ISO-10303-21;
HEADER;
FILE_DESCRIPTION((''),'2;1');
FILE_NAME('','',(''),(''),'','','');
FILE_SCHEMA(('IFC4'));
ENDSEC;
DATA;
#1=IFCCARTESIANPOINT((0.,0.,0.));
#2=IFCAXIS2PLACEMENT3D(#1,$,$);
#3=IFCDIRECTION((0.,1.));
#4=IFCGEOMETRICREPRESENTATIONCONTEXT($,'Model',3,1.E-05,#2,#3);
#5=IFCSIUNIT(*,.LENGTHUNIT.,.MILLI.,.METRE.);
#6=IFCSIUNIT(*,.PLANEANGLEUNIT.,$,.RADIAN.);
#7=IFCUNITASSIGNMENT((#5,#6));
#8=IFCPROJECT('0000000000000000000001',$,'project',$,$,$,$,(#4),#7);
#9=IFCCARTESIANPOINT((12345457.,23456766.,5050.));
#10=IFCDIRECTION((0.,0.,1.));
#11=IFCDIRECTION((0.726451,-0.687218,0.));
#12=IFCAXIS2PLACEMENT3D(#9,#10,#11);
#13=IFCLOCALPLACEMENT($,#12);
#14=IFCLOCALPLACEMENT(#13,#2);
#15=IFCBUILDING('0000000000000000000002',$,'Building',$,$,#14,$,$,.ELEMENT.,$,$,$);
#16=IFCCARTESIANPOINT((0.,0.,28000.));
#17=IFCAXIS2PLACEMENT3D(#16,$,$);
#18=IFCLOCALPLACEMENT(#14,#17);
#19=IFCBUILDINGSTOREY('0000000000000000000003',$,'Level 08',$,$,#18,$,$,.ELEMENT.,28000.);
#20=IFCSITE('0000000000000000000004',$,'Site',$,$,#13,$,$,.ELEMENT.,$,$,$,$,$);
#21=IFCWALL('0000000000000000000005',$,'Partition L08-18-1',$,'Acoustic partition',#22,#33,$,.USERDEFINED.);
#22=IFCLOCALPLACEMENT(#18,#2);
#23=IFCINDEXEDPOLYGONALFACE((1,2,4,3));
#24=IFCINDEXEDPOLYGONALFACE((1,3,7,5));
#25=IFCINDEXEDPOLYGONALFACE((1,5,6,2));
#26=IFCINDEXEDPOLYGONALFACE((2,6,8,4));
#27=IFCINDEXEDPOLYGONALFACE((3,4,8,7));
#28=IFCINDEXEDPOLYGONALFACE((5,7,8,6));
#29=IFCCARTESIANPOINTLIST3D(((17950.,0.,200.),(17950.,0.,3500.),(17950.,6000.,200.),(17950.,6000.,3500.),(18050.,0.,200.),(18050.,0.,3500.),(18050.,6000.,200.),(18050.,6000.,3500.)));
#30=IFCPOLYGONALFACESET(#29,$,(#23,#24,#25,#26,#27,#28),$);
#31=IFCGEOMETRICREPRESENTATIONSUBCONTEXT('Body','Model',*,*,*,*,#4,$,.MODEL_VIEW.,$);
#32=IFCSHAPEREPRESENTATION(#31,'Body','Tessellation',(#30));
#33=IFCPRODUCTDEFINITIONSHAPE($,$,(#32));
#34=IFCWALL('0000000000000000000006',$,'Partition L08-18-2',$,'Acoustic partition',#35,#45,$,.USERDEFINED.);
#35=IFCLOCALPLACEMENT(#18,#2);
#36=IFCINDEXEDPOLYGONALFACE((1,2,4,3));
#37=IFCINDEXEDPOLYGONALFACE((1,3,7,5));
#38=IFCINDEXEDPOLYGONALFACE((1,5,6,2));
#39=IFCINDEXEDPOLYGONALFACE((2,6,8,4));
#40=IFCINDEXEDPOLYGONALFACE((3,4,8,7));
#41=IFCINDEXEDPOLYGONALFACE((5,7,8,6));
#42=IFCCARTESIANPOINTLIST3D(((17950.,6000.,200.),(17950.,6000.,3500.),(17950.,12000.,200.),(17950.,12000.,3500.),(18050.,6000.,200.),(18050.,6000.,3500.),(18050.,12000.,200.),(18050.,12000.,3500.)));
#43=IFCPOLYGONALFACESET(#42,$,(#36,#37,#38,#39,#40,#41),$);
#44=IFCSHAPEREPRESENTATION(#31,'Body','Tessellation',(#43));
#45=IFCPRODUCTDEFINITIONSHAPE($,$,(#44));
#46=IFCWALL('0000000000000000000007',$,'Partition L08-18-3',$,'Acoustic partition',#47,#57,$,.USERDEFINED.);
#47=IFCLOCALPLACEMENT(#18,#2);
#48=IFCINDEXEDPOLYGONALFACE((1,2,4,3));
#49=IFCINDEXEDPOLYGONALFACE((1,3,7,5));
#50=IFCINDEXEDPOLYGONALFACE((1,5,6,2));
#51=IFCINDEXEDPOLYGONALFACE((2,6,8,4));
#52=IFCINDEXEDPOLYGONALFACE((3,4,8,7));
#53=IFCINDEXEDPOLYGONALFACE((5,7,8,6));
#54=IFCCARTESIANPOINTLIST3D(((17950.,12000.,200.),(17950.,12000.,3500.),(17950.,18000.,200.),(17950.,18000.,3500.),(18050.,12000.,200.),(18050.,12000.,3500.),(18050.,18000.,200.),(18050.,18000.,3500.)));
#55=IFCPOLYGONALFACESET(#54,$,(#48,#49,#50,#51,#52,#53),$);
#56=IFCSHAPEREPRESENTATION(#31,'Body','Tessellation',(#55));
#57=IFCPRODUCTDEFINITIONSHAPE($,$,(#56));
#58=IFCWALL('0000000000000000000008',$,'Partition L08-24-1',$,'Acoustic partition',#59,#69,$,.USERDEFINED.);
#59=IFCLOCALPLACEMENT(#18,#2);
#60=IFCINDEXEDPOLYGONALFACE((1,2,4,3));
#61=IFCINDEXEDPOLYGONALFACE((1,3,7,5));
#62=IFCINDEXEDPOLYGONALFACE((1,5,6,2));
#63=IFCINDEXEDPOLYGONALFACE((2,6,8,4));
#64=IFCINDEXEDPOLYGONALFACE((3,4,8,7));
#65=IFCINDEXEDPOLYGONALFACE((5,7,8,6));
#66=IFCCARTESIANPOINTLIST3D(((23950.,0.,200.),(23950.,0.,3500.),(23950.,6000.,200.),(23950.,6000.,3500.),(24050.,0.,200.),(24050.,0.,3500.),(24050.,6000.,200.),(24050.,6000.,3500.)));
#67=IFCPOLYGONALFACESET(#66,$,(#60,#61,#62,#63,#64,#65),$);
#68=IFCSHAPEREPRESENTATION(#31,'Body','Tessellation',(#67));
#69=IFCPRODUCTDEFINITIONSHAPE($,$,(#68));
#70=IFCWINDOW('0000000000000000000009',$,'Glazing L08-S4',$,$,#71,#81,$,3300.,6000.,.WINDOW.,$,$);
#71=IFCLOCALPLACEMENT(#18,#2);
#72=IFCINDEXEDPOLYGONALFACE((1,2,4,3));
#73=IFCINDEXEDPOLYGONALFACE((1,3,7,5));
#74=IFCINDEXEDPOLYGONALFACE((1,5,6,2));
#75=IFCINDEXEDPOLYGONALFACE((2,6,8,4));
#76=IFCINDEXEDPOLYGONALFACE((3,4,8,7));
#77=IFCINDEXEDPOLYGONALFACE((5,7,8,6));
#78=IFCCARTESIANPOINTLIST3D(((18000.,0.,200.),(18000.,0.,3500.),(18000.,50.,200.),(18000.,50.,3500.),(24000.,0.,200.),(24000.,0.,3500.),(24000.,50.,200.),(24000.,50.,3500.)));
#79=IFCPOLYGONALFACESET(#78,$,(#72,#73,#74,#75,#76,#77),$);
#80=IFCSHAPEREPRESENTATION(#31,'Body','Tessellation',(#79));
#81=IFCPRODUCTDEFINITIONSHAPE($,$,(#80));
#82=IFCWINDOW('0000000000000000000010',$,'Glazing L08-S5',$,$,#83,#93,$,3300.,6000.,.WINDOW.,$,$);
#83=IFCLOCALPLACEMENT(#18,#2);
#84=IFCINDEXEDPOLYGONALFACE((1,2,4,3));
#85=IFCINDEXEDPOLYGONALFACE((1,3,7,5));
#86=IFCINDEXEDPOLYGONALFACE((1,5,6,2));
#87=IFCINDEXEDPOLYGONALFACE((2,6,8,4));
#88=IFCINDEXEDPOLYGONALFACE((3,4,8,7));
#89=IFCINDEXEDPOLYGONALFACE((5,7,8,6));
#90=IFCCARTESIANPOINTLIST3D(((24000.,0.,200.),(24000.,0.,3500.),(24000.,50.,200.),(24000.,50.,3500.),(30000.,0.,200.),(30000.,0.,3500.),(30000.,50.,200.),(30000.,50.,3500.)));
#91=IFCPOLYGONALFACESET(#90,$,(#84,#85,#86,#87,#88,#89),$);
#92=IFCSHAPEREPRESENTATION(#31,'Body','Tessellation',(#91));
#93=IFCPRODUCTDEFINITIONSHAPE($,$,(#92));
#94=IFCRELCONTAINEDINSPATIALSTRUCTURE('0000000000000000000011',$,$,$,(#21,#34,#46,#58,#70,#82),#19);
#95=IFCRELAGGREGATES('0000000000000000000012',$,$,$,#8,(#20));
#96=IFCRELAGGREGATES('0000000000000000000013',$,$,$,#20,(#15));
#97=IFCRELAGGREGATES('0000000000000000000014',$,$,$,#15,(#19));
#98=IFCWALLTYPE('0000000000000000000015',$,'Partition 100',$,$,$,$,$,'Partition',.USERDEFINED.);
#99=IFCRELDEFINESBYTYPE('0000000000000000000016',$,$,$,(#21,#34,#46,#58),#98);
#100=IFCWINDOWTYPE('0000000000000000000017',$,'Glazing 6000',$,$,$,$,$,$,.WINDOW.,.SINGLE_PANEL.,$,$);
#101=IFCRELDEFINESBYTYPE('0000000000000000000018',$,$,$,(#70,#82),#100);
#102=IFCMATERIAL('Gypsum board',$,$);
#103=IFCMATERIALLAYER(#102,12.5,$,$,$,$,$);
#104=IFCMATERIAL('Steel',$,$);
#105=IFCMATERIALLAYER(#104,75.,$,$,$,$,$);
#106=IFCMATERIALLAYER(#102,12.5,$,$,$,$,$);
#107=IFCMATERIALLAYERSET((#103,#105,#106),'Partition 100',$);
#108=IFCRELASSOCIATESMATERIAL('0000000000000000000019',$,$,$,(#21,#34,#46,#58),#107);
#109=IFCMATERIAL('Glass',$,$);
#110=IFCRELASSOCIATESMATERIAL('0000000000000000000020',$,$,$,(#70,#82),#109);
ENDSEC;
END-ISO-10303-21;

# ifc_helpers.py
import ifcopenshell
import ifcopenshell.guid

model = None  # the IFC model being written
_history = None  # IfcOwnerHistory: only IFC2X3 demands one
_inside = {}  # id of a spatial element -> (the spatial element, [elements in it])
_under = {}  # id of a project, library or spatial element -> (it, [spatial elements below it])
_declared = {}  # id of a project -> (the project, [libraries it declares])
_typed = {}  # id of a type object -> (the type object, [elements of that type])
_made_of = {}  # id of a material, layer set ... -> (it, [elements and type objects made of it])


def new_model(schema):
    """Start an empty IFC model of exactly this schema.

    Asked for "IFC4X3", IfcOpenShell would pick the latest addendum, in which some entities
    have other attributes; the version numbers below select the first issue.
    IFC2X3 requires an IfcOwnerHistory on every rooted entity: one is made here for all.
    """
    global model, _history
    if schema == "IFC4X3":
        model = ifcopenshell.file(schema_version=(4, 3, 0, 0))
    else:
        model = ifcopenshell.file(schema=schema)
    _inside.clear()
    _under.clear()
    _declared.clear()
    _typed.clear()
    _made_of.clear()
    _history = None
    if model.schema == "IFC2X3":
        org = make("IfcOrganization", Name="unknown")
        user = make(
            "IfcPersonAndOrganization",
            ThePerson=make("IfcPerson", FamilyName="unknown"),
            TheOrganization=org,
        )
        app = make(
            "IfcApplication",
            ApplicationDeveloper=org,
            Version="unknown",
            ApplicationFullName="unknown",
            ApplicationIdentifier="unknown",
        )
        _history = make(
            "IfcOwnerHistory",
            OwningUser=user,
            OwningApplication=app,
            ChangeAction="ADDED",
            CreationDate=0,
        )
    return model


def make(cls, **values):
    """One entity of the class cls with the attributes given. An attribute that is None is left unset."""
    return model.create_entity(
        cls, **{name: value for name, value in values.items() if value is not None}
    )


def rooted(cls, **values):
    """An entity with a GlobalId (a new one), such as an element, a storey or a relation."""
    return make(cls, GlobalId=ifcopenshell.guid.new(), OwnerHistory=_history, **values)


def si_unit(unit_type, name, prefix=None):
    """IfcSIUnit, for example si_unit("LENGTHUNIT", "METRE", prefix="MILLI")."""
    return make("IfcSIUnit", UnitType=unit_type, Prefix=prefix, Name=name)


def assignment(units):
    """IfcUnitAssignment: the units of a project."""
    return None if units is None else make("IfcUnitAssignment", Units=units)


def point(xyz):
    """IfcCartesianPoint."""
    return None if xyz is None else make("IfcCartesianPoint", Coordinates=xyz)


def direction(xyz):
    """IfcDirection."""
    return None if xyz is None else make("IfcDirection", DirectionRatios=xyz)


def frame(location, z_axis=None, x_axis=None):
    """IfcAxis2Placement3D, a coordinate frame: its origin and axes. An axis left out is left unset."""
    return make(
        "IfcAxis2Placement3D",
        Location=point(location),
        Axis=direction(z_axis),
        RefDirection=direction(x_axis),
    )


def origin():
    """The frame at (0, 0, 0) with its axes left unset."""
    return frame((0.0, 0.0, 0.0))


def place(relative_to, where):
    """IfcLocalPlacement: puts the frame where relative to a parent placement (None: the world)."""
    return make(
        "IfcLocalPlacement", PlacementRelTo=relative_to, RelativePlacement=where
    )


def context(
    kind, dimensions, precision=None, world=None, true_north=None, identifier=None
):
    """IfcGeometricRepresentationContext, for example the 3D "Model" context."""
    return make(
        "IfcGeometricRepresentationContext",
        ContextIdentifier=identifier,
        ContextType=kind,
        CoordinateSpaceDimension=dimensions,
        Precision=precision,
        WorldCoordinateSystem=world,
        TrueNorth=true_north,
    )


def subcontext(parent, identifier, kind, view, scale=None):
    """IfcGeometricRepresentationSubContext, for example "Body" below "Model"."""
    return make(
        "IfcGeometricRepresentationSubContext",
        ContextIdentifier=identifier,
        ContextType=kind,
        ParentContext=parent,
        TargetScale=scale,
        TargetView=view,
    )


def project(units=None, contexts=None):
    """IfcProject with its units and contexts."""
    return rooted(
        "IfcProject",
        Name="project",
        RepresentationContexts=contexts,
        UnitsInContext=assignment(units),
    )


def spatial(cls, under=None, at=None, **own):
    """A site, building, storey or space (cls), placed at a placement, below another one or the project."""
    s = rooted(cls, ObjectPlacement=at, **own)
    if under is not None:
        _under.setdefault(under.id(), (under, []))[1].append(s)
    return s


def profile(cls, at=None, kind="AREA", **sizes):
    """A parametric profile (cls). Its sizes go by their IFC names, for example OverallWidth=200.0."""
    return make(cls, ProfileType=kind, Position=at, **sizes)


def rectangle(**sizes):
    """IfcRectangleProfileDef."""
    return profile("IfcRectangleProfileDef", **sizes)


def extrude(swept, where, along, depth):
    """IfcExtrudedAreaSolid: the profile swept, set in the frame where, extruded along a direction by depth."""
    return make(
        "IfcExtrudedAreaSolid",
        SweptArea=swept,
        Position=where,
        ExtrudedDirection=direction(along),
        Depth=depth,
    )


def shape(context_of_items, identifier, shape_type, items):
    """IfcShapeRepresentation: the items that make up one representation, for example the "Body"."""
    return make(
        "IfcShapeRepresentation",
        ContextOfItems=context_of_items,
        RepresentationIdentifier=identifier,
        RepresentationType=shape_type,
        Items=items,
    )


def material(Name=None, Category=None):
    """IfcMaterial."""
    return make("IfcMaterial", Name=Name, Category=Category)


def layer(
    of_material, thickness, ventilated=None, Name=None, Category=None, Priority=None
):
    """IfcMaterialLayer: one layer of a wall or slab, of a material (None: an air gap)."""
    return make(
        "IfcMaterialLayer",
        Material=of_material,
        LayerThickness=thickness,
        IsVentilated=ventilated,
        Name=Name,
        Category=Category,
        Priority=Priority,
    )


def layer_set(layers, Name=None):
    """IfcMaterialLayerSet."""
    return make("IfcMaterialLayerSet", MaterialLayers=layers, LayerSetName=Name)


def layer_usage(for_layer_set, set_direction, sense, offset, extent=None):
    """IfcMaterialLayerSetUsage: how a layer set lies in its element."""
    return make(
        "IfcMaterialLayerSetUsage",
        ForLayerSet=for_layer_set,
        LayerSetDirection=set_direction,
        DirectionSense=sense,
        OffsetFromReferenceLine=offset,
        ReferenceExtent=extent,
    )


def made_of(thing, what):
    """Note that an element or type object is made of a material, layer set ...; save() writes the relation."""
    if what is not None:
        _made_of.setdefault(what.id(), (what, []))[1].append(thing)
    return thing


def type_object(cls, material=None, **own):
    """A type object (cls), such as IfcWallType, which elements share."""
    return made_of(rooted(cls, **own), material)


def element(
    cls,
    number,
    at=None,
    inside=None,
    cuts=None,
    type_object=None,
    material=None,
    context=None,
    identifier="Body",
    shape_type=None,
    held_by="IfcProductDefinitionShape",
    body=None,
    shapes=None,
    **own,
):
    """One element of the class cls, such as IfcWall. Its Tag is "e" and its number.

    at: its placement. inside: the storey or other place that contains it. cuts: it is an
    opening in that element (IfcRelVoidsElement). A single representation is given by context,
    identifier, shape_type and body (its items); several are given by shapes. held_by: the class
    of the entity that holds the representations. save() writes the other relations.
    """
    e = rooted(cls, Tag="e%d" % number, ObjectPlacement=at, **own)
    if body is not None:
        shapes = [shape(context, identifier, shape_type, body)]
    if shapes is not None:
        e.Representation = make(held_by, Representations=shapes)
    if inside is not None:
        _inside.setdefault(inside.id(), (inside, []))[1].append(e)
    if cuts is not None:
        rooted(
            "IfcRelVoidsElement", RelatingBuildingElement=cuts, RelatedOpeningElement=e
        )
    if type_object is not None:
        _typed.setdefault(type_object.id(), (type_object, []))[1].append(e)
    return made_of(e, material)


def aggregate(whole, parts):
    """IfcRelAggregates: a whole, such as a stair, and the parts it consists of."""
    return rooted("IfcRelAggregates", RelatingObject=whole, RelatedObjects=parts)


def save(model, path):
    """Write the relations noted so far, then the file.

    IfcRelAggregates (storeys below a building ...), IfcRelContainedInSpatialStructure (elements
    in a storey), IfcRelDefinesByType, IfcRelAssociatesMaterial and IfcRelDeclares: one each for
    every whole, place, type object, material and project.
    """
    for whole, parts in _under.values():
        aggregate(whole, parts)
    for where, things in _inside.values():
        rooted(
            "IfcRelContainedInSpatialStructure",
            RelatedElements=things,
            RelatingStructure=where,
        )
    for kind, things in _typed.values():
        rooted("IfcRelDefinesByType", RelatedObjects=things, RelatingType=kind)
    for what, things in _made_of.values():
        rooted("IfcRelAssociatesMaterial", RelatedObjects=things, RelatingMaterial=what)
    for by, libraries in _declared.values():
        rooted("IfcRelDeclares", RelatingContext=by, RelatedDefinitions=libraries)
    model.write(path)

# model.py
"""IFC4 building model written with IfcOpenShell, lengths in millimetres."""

from ifc_helpers import new_model, si_unit, direction, frame, origin, place, context, subcontext, project, spatial, rectangle, extrude, material, layer, layer_set, layer_usage, type_object, element, save


model = new_model("IFC4")

# Units and contexts
model_context = context("Model", 3, precision=1e-05, world=origin(), true_north=direction((0.0, 1.0)))
body_context = subcontext(model_context, "Body", "Model", "MODEL_VIEW")
ifc_project = project(units=[si_unit("LENGTHUNIT", "METRE", prefix="MILLI"), si_unit("PLANEANGLEUNIT", "RADIAN")], contexts=[model_context])

# Site, building, storey
site_placement = place(None, frame((12345457.0, 23456766.0, 5050.0), z_axis=(0.0, 0.0, 1.0), x_axis=(0.726451, -0.687218, 0.0)))
site = spatial("IfcSite", under=ifc_project, at=site_placement, Name="Site", CompositionType="ELEMENT")
building_placement = place(site_placement, origin())
building = spatial("IfcBuilding", under=site, at=building_placement, Name="Building", CompositionType="ELEMENT")
storey_placement = place(building_placement, frame((0.0, 0.0, 28000.0)))
storey = spatial("IfcBuildingStorey", under=building, at=storey_placement, Name="Level 08", CompositionType="ELEMENT", Elevation=28000.0)

# Shared definitions
ifc_material_1 = material(Name="Steel")

# Walls
ifc_material_2 = material(Name="Gypsum board")
ifc_layer_1 = layer(ifc_material_2, 12.5)
ifc_layer_2 = layer(ifc_material_1, 75.0)
ifc_layer_3 = layer(ifc_material_2, 12.5)
ifc_layer_set = layer_set([ifc_layer_1, ifc_layer_2, ifc_layer_3], Name="Partition 100")
ifc_layer_usage = layer_usage(ifc_layer_set, "AXIS2", "POSITIVE", 0.0)
wall_type = type_object("IfcWallType", Name="Partition 100", ElementType="Partition", PredefinedType="USERDEFINED")
for number, where, name in (
    (1, (17950.0, 0.0, 200.0), "Partition L08-18-1"),
    (2, (17950.0, 6000.0, 200.0), "Partition L08-18-2"),
    (3, (17950.0, 12000.0, 200.0), "Partition L08-18-3"),
    (4, (23950.0, 0.0, 200.0), "Partition L08-24-1"),
):
    element("IfcWall", number, at=place(storey_placement, frame(where)), inside=storey, type_object=wall_type, material=ifc_layer_usage, Name=name, ObjectType="Acoustic partition", PredefinedType="USERDEFINED", context=body_context, shape_type="SweptSolid", body=[
        extrude(rectangle(XDim=100.0, YDim=6000.0), frame((50.0, 3000.0, 0.0)), (0.0, 0.0, 1.0), 3300.0),
    ])

# Windows
ifc_material_3 = material(Name="Glass")
window_type = type_object("IfcWindowType", Name="Glazing 6000", PartitioningType="SINGLE_PANEL", PredefinedType="WINDOW")
for number, where, name in (
    (5, (18000.0, 0.0, 200.0), "Glazing L08-S4"),
    (6, (24000.0, 0.0, 200.0), "Glazing L08-S5"),
):
    element("IfcWindow", number, at=place(storey_placement, frame(where)), inside=storey, type_object=window_type, material=ifc_material_3, Name=name, OverallHeight=3300.0, OverallWidth=6000.0, PredefinedType="WINDOW", context=body_context, shape_type="SweptSolid", body=[
        extrude(rectangle(XDim=6000.0, YDim=50.0), frame((3000.0, 25.0, 0.0)), (0.0, 0.0, 1.0), 3300.0),
    ])

save(model, "model.ifc")
